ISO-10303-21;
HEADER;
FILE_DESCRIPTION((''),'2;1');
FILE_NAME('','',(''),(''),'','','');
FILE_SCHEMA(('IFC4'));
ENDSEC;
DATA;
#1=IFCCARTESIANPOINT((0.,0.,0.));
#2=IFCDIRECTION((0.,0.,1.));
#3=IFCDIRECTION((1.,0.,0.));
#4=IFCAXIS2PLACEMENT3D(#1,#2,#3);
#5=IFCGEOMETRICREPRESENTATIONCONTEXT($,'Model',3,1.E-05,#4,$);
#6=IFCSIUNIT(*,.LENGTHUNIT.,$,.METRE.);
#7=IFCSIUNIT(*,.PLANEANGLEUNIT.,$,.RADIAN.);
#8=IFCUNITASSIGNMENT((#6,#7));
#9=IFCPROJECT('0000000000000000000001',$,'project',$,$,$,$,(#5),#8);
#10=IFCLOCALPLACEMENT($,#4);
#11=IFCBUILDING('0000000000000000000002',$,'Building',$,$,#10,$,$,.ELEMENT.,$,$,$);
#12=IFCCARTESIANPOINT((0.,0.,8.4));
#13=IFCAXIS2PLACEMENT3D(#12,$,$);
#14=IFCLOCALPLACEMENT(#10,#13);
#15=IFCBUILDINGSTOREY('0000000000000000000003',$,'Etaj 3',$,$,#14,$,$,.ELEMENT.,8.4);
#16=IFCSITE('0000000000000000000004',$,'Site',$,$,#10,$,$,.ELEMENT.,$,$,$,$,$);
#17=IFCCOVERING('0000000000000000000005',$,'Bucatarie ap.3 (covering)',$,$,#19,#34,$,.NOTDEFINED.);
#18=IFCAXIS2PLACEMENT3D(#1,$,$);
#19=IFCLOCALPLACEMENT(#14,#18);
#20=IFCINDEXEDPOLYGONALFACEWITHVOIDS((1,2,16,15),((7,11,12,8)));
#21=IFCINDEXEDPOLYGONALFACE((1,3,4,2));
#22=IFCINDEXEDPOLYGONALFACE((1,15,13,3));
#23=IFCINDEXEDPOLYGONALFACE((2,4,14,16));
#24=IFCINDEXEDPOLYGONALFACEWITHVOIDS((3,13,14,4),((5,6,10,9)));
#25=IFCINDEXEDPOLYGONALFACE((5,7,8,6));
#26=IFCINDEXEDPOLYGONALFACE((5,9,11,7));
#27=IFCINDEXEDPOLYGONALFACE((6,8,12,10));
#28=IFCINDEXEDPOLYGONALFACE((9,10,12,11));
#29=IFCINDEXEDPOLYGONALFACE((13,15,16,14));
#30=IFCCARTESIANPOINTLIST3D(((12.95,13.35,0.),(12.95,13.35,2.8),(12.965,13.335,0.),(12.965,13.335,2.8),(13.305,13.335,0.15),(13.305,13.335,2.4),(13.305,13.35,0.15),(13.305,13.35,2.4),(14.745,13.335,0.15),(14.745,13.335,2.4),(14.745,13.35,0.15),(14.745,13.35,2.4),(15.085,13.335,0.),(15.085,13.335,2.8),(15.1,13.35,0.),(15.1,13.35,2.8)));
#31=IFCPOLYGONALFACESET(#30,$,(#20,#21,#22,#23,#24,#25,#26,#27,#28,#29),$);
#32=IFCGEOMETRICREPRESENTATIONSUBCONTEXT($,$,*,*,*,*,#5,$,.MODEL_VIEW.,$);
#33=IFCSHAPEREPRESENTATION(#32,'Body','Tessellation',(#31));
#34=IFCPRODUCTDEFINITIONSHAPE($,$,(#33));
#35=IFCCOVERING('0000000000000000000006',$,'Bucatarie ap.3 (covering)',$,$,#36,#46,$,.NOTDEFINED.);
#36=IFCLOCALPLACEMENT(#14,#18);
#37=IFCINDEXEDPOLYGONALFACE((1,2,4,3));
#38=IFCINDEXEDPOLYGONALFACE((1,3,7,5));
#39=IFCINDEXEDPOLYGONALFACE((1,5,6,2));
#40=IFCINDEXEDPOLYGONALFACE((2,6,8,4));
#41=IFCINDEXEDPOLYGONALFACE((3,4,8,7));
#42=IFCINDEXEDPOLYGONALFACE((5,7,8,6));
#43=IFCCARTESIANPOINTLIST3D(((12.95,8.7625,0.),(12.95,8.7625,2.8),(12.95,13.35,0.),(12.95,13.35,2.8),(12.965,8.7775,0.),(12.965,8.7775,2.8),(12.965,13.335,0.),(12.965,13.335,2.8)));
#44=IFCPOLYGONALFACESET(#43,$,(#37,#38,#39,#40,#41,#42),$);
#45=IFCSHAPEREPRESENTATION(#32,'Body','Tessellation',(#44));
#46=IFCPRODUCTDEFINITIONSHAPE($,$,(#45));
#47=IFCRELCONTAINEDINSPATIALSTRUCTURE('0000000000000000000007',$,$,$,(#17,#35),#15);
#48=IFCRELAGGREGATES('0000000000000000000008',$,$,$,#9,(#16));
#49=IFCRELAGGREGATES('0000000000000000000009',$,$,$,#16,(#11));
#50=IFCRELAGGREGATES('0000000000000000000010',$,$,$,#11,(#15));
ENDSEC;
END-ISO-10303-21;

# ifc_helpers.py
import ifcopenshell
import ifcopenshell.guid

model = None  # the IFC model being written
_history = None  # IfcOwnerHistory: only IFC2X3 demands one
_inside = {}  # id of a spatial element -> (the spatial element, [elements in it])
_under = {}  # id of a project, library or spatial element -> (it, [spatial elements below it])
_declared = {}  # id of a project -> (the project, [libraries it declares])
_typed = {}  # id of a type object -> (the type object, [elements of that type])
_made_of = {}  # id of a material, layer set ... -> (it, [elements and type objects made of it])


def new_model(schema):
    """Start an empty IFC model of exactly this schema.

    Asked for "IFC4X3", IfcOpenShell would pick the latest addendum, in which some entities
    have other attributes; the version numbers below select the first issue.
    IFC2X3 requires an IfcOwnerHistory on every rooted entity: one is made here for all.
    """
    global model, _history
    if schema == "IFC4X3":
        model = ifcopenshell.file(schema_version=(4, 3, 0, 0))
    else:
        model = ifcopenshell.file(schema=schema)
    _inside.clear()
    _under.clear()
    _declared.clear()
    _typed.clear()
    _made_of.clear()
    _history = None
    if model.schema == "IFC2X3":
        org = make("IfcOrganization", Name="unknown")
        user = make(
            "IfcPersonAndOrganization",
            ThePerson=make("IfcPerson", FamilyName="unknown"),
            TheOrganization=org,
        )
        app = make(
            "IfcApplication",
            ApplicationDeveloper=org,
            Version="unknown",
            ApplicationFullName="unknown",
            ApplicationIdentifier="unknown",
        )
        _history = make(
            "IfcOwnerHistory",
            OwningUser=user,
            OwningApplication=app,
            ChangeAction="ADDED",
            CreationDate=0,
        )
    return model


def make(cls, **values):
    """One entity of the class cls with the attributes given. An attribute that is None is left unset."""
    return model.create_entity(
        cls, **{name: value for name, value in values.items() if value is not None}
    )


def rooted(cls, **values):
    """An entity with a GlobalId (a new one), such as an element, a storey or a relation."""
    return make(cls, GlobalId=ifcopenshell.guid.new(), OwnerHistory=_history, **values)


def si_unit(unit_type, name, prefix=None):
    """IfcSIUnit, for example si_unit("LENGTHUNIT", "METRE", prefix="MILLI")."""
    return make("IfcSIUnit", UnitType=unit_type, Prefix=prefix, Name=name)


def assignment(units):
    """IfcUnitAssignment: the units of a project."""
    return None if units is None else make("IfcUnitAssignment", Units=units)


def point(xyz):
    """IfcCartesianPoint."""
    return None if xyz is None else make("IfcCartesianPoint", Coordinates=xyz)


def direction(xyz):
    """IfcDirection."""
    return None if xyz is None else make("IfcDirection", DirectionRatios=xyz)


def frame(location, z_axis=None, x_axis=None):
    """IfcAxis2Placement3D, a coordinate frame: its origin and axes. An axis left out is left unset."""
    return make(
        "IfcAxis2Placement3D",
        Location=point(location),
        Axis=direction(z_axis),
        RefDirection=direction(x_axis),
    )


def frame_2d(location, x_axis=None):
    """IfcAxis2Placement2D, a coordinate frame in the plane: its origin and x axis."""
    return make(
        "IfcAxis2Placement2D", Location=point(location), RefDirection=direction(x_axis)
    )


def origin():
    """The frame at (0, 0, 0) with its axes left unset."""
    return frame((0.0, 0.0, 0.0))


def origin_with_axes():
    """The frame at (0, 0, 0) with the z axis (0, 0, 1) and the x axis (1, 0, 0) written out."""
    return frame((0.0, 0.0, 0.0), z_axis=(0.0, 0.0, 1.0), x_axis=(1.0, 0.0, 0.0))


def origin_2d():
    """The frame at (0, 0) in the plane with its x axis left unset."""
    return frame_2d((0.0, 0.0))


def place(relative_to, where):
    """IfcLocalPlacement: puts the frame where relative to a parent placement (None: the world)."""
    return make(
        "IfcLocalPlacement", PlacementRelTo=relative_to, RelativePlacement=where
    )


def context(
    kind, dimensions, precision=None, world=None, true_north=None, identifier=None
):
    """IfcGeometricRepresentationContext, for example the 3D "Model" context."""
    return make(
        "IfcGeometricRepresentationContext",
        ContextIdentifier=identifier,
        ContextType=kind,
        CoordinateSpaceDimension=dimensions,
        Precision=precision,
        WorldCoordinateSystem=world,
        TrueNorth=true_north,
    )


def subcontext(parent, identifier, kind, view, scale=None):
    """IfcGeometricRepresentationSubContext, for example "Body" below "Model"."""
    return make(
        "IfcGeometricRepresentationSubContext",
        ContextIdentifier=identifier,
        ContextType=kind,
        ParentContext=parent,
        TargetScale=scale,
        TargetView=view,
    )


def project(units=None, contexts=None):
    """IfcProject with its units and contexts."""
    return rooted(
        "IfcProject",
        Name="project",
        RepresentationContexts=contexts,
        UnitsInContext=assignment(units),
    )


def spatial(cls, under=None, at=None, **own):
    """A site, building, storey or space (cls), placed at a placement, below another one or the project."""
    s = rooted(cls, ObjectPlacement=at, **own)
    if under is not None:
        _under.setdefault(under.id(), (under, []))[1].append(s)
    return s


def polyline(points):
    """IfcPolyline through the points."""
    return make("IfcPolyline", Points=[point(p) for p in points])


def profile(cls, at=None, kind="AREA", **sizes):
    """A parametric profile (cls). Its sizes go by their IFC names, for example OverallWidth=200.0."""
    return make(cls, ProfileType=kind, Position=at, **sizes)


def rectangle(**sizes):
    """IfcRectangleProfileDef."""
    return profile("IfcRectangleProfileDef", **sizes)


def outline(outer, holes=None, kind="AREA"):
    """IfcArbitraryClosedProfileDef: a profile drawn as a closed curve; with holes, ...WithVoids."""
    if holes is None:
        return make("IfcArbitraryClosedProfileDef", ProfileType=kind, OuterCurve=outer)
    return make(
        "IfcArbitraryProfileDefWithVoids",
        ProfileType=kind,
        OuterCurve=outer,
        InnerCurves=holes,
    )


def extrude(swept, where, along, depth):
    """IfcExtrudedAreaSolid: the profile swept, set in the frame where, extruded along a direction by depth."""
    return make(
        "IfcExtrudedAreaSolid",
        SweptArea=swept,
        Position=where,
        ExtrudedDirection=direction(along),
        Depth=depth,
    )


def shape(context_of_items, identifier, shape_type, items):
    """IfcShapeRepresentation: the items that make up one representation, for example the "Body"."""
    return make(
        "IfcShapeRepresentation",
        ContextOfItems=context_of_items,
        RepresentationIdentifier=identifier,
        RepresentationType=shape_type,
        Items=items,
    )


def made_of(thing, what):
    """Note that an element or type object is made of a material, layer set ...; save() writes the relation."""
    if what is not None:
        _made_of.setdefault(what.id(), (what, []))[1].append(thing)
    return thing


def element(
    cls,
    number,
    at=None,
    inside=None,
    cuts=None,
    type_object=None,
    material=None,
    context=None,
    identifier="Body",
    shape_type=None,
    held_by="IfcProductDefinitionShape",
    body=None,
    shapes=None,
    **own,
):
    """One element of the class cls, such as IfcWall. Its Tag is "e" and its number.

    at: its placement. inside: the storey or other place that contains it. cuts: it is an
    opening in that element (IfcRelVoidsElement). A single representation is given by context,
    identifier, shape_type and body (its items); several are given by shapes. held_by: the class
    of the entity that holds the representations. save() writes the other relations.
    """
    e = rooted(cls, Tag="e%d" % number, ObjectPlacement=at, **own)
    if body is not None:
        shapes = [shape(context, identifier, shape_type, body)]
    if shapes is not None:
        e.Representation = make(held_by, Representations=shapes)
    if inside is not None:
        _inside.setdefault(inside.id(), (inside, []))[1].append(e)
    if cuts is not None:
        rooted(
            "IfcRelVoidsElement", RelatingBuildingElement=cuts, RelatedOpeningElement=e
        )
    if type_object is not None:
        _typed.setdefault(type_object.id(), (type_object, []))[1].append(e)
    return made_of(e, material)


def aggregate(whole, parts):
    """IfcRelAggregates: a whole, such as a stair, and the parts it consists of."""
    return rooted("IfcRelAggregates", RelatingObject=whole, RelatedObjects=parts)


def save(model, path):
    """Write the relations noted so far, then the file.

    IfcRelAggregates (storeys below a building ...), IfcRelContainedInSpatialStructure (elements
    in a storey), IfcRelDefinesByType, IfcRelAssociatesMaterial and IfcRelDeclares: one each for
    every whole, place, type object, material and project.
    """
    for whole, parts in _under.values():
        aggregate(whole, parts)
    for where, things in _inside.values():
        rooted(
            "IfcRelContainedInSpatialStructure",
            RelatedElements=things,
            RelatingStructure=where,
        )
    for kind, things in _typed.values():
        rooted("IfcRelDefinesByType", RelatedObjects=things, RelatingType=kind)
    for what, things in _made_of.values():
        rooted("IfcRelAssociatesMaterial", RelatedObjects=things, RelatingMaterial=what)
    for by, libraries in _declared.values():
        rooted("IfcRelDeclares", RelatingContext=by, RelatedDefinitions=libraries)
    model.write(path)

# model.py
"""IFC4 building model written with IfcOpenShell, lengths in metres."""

from ifc_helpers import new_model, si_unit, frame, origin, origin_with_axes, origin_2d, place, context, subcontext, project, spatial, polyline, rectangle, outline, extrude, element, save


model = new_model("IFC4")

# Units and contexts
model_context = context("Model", 3, precision=1e-05, world=origin_with_axes())
sub_context = subcontext(model_context, None, None, "MODEL_VIEW")
ifc_project = project(units=[si_unit("LENGTHUNIT", "METRE"), si_unit("PLANEANGLEUNIT", "RADIAN")], contexts=[model_context])

# Site, building, storey
placement = place(None, origin_with_axes())
site = spatial("IfcSite", under=ifc_project, at=placement, Name="Site", CompositionType="ELEMENT")
building = spatial("IfcBuilding", under=site, at=placement, Name="Building", CompositionType="ELEMENT")
storey_placement = place(placement, frame((0.0, 0.0, 8.4)))
storey = spatial("IfcBuildingStorey", under=building, at=storey_placement, Name="Etaj 3", CompositionType="ELEMENT", Elevation=8.4)

# Covering, opening
covering_1_placement = place(storey_placement, origin_with_axes())
covering_1 = element("IfcCovering", 1, at=covering_1_placement, inside=storey, Name="Bucatarie ap.3 (covering)", PredefinedType="NOTDEFINED", context=sub_context, shape_type="SweptSolid", body=[
    extrude(outline(polyline([(15.1, 13.35), (12.95, 13.35), (12.965, 13.335), (15.085, 13.335), (15.1, 13.35)])), origin(), (0.0, 0.0, 1.0), 2.8),
])
opening_1_placement = place(covering_1_placement, frame((14.025, 13.665, 0.15), z_axis=(0.0, -1.0, 0.0), x_axis=(1.0, 0.0, 0.0)))
element("IfcOpeningElement", 2, at=opening_1_placement, cuts=covering_1, PredefinedType="OPENING", context=sub_context, shape_type="SweptSolid", body=[
    extrude(rectangle(XDim=1.44, YDim=2.25, at=origin_2d()), frame((0.0, 1.125, 0.0)), (0.0, 0.0, 1.0), 0.38),
])

# Covering
covering_2_placement = place(storey_placement, origin_with_axes())
element("IfcCovering", 3, at=covering_2_placement, inside=storey, Name="Bucatarie ap.3 (covering)", PredefinedType="NOTDEFINED", context=sub_context, shape_type="SweptSolid", body=[
    extrude(outline(polyline([(12.95, 13.35), (12.95, 8.7625), (12.965, 8.7775), (12.965, 13.335), (12.95, 13.35)])), origin(), (0.0, 0.0, 1.0), 2.8),
])

save(model, "model.ifc")
